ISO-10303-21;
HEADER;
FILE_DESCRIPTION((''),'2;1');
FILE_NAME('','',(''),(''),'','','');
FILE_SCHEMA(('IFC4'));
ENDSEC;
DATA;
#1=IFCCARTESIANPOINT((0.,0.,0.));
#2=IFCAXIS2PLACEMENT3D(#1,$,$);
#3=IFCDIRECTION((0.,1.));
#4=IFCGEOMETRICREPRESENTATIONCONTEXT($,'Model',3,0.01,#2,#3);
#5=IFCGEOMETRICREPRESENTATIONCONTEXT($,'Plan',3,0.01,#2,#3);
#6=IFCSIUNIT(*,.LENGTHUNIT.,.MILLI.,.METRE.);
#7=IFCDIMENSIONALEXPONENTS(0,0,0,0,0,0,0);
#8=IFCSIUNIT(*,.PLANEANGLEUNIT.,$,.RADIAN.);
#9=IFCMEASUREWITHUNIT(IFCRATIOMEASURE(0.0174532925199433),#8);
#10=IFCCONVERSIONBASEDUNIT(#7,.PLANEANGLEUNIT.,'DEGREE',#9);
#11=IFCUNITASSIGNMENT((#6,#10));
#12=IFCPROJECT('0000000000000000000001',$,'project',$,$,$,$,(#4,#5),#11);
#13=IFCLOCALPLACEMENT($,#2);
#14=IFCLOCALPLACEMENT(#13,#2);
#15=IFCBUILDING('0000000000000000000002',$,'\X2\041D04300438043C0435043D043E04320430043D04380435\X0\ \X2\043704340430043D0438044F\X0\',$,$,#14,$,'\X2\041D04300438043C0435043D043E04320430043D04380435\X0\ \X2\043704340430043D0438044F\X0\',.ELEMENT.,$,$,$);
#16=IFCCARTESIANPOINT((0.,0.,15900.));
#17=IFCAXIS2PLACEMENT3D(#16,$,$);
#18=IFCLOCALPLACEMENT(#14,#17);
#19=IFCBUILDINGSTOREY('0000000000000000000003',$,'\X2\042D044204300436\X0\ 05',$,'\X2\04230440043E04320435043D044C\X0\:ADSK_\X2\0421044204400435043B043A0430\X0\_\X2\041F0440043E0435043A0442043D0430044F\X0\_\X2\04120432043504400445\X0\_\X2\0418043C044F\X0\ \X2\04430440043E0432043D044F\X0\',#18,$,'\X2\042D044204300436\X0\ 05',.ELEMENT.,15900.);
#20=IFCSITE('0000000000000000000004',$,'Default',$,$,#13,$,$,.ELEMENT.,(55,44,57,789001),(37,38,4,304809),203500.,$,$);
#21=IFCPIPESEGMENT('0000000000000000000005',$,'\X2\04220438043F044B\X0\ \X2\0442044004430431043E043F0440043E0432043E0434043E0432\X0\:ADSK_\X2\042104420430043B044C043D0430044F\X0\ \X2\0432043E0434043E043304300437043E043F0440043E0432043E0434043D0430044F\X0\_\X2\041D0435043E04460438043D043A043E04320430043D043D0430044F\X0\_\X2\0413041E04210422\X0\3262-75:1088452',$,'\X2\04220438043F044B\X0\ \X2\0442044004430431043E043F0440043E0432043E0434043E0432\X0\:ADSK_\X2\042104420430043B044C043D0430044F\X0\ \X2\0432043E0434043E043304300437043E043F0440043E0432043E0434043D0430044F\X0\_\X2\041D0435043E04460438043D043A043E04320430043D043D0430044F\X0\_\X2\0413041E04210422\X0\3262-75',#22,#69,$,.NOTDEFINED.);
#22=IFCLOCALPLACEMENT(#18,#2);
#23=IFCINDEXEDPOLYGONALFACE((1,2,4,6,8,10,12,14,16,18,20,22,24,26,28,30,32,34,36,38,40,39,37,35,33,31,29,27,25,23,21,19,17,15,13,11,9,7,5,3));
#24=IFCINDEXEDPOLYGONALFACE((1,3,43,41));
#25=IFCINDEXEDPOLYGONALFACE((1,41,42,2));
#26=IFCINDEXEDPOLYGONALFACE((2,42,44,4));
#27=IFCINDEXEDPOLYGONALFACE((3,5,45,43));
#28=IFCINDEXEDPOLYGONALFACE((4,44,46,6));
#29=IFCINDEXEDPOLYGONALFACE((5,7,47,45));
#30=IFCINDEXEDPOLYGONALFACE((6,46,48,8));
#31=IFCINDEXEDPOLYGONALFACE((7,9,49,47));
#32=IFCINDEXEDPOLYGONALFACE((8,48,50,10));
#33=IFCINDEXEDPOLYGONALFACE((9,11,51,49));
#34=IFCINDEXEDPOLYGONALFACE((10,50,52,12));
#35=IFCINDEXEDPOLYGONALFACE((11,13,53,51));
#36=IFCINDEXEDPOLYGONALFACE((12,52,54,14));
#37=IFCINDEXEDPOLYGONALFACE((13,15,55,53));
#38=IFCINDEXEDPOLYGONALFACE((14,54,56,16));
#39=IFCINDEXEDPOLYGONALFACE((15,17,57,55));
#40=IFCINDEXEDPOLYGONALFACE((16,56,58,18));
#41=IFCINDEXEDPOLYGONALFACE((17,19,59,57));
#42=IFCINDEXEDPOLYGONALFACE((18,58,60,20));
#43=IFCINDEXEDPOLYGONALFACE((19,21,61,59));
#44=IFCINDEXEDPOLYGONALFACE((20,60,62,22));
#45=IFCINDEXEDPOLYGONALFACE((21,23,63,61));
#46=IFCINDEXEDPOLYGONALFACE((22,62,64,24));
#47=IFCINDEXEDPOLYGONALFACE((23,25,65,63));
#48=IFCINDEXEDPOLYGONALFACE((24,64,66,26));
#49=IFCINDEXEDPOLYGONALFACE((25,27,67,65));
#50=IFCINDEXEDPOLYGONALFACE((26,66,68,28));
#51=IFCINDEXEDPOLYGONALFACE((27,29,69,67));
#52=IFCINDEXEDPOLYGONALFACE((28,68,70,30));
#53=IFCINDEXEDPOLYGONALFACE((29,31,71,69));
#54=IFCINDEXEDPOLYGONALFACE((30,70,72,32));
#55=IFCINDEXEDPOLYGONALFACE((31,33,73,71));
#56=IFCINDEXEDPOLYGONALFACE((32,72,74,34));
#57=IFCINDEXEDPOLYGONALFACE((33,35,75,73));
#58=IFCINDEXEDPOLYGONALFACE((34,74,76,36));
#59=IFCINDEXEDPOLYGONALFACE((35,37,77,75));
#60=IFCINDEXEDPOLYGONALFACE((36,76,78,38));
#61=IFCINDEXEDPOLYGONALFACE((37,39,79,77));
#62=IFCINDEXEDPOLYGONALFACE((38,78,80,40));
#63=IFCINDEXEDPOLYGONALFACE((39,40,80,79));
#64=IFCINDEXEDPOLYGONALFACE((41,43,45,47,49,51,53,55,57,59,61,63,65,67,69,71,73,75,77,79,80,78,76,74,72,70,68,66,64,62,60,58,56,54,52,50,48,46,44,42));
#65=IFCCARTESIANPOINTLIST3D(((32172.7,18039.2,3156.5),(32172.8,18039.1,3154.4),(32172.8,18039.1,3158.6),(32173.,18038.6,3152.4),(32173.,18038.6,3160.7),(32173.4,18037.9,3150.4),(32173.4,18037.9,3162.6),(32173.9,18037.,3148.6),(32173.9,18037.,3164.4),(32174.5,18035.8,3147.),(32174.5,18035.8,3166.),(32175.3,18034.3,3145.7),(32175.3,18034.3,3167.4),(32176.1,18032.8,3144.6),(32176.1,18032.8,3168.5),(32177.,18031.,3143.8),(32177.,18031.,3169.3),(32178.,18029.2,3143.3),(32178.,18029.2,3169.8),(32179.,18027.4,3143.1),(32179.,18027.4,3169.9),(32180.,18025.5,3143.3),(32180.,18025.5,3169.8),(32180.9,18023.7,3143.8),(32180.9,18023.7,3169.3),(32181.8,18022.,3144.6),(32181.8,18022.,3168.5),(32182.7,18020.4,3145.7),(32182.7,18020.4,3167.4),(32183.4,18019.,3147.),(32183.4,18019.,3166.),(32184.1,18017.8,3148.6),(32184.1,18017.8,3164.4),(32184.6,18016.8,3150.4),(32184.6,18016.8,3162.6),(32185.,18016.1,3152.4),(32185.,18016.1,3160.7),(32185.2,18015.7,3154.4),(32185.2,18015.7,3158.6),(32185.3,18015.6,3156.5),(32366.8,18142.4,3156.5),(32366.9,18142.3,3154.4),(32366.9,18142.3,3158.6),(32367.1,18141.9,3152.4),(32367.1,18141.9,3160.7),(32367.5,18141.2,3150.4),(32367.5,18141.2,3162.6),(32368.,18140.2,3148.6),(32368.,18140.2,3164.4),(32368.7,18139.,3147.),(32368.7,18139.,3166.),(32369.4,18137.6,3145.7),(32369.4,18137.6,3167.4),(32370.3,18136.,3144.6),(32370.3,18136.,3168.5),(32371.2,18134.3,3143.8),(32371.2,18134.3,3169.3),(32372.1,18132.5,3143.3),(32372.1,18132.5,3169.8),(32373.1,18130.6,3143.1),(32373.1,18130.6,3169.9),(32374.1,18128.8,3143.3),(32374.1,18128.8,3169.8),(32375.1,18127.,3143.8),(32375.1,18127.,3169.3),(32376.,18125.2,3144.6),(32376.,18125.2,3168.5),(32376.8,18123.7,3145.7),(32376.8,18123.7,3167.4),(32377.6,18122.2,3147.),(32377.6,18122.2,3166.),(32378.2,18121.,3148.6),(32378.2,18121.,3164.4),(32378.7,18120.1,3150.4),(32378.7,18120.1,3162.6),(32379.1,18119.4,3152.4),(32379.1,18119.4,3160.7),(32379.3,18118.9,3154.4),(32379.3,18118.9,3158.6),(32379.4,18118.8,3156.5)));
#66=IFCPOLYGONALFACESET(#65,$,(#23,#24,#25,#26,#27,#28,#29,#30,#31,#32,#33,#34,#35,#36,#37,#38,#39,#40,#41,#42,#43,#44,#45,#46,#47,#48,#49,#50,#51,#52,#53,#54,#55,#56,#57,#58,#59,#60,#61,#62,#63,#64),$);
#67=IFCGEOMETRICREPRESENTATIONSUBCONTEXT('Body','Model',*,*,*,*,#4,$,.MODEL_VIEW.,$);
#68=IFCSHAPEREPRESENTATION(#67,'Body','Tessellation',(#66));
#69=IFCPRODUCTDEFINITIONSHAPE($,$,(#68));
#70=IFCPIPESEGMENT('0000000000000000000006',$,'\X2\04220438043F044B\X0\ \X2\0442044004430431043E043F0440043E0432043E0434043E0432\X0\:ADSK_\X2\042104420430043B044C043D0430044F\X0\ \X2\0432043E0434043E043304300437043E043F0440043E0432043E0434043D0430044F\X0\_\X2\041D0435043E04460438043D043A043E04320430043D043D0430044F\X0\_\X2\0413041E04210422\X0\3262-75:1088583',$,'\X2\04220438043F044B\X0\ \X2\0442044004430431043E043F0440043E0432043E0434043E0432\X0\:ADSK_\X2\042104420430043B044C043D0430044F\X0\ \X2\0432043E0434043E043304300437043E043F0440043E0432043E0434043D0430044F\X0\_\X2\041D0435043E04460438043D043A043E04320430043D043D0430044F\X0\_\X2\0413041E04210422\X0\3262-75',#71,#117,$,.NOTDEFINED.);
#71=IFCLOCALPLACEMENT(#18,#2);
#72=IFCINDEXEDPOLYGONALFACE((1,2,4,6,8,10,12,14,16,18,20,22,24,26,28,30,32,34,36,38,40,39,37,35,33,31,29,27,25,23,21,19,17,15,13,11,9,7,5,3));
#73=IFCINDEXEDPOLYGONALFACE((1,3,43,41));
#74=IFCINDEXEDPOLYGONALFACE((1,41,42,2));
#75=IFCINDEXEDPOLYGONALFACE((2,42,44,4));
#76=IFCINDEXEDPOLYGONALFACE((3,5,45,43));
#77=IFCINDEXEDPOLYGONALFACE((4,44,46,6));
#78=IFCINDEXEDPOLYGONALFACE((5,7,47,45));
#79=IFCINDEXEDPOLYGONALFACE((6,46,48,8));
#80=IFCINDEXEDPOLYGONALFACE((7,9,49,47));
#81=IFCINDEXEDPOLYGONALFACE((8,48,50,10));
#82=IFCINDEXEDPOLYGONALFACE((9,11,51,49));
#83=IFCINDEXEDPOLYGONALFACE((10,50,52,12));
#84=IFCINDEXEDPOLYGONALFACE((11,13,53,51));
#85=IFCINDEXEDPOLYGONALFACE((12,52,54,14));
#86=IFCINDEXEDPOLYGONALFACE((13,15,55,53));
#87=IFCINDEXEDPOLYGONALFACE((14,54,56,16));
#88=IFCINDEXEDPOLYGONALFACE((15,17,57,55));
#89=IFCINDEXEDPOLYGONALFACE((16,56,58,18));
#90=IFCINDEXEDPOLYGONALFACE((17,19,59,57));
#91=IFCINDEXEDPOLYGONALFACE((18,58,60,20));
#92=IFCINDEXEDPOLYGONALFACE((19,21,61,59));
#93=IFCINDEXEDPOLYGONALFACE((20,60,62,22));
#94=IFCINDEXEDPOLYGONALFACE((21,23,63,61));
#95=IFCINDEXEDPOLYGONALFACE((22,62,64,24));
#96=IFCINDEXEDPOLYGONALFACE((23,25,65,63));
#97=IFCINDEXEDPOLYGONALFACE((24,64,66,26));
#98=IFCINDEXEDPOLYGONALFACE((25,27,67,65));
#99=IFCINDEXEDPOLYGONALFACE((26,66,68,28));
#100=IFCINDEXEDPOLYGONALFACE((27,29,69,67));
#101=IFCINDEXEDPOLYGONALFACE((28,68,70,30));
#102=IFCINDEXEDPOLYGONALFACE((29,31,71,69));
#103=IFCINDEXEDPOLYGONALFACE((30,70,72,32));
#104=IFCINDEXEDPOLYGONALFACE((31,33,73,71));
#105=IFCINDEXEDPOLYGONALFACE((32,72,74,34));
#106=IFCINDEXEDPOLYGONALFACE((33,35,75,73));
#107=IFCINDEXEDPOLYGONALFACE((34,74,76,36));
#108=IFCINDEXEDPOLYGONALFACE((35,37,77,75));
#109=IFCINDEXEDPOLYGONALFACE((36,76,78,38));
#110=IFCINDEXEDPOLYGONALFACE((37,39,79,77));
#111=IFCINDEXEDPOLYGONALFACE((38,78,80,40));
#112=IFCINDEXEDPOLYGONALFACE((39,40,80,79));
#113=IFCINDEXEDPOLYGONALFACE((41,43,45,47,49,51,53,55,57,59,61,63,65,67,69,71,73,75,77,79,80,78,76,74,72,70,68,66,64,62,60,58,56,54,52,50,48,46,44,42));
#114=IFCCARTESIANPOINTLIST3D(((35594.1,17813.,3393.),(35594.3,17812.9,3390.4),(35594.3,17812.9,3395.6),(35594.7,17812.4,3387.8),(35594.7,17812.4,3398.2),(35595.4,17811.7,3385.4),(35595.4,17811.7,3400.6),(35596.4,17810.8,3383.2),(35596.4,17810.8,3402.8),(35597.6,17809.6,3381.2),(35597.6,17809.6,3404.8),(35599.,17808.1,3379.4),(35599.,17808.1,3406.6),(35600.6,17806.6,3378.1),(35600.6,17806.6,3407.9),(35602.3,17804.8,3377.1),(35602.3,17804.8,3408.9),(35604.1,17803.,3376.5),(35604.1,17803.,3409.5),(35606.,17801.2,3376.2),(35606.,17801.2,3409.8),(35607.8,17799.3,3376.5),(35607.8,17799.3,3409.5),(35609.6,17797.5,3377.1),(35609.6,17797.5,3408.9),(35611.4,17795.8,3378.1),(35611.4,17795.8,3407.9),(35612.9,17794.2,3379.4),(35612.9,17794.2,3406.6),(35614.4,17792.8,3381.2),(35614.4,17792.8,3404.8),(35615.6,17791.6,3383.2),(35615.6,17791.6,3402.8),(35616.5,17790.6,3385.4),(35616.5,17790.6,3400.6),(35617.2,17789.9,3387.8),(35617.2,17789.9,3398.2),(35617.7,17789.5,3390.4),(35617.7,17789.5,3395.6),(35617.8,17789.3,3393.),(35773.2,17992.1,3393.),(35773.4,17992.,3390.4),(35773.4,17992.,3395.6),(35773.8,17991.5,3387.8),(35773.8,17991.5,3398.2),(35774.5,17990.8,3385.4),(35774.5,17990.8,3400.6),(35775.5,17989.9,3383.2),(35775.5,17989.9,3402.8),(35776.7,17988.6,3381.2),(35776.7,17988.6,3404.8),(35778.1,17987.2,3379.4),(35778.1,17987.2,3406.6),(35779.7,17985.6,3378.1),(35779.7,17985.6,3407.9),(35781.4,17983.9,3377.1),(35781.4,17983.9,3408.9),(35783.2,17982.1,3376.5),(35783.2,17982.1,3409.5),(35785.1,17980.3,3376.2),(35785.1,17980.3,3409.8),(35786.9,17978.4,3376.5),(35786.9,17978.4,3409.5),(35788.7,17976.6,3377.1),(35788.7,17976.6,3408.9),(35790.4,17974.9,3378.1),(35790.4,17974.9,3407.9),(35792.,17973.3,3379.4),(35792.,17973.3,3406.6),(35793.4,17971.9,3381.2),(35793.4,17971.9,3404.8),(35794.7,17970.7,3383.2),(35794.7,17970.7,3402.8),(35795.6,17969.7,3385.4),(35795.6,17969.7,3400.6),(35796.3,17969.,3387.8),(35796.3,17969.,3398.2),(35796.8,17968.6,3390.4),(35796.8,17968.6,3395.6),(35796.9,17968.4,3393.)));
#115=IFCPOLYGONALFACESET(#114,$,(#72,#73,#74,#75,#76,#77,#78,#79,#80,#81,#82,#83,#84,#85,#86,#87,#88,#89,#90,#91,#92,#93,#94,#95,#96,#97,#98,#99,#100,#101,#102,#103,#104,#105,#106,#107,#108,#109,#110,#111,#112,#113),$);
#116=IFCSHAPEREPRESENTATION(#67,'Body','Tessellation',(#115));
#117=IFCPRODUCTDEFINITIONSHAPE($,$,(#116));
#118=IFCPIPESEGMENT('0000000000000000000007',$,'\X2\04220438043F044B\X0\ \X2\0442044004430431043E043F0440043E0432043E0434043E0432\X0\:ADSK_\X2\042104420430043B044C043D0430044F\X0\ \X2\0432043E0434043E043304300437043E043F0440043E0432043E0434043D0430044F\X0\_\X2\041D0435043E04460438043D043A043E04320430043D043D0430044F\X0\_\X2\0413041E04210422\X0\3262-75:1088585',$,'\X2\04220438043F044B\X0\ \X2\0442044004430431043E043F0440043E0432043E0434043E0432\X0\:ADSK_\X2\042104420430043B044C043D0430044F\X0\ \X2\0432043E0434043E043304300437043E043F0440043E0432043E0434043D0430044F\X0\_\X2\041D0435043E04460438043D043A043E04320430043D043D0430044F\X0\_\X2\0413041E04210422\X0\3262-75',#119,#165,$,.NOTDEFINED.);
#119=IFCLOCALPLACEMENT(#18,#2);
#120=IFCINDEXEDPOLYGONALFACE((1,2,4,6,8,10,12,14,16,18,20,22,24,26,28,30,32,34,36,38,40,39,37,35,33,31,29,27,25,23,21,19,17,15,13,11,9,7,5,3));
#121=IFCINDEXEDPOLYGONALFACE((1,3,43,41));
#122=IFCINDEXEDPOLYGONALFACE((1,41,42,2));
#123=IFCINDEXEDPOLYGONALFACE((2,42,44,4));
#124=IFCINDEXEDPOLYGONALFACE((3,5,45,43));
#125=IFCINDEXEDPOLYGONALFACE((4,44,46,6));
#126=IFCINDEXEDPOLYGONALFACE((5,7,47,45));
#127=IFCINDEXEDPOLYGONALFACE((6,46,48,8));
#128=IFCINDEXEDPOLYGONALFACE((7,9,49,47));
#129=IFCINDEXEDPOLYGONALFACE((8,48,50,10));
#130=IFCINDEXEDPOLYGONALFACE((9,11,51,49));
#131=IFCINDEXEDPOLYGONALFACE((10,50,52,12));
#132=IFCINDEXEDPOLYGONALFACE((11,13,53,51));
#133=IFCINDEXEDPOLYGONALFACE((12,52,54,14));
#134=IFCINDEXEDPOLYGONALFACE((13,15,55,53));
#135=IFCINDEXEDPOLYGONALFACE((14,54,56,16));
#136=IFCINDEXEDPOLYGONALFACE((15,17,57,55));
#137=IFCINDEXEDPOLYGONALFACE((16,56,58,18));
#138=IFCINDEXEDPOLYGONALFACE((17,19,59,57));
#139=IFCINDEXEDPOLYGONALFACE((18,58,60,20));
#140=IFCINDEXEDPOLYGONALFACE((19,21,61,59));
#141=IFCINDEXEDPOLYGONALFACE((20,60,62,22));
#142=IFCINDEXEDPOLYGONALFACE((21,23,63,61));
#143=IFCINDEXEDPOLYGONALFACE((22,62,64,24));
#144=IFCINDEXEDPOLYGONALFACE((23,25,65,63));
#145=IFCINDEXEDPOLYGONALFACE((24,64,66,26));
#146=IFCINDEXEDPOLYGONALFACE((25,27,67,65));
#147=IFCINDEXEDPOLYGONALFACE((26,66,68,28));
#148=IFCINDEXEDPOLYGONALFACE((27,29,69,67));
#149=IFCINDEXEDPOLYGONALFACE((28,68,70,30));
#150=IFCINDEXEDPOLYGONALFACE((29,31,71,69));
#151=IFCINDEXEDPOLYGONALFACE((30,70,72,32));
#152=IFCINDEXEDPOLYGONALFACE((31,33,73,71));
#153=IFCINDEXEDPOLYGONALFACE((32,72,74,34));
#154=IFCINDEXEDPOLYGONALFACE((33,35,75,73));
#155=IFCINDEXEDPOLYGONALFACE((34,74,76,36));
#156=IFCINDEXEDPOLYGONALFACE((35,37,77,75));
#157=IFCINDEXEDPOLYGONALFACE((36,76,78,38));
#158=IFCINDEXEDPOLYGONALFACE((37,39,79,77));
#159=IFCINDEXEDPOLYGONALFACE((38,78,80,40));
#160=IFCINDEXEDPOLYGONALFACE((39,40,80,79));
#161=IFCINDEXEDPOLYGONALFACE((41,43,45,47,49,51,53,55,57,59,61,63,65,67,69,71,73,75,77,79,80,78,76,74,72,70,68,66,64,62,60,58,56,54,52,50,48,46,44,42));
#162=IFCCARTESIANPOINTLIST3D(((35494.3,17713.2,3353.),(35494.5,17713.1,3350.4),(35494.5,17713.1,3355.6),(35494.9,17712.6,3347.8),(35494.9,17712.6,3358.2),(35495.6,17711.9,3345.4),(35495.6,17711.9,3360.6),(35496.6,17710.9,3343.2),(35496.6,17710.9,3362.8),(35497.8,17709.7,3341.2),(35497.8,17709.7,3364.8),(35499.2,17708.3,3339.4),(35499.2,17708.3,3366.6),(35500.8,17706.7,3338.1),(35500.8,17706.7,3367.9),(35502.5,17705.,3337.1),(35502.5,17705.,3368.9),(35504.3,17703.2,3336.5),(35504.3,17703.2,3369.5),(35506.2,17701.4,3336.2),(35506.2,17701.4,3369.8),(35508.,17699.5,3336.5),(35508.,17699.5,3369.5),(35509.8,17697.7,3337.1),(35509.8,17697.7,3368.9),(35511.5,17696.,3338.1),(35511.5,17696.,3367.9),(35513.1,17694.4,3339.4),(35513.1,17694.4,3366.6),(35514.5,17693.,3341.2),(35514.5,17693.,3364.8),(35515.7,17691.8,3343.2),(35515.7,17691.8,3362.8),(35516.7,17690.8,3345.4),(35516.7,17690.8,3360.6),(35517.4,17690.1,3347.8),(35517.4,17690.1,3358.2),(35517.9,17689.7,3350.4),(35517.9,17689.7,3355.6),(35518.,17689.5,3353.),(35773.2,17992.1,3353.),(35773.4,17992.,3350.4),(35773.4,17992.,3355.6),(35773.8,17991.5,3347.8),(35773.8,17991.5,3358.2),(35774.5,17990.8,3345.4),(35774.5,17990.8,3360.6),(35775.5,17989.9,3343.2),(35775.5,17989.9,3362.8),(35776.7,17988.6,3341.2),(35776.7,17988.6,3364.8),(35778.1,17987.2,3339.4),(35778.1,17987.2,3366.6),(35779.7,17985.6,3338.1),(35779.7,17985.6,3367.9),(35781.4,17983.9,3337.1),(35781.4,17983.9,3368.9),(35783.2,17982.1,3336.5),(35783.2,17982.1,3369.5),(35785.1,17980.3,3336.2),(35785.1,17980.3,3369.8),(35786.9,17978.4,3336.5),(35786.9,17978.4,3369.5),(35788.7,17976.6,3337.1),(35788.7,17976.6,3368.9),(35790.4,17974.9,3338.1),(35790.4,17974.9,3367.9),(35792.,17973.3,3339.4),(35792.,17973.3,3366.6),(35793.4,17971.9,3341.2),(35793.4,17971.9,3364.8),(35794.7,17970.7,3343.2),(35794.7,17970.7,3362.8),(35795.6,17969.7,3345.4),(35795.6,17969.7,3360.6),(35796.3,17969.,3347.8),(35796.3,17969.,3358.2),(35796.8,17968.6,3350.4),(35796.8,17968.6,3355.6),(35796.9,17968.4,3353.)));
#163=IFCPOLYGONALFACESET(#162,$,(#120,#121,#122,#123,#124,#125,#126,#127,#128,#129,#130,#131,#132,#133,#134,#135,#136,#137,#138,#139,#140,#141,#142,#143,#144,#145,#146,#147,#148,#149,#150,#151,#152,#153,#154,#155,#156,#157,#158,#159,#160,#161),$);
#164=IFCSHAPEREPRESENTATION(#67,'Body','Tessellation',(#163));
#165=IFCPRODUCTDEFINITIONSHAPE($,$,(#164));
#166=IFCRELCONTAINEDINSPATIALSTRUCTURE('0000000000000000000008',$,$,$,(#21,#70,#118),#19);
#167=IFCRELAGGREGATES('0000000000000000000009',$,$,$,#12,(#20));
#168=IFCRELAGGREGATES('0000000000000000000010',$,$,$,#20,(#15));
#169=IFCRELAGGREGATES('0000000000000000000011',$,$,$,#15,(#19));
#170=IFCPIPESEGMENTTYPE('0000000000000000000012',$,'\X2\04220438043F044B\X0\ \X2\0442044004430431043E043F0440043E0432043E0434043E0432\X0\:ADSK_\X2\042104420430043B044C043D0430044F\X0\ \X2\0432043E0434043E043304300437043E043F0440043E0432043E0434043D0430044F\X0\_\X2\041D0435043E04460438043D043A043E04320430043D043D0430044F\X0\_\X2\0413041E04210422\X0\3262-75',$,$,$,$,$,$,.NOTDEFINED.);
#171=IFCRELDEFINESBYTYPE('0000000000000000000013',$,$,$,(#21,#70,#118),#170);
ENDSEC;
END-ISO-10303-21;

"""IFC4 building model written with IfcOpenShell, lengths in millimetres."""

from ifc_helpers import new_model, entity, si_unit, converted_unit, direction, frame, origin, place, context, subcontext, project, spatial, indexed_curve, outline, extrude, type_object, element, save


model = new_model("IFC4")

# Units and contexts
model_context = context("Model", 3, precision=0.01, world=origin(), true_north=direction((0.0, 1.0)))
plan_context = context("Plan", 3, precision=0.01, world=origin(), true_north=direction((0.0, 1.0)))
body_context = subcontext(model_context, "Body", "Model", "MODEL_VIEW")
ifc_project = project(units=[si_unit("LENGTHUNIT", "METRE", prefix="MILLI"), converted_unit("PLANEANGLEUNIT", "DEGREE", entity("IfcRatioMeasure", 0.0174532925199433), si_unit("PLANEANGLEUNIT", "RADIAN"), dimensions=[0, 0, 0, 0, 0, 0, 0])], contexts=[model_context, plan_context])

# Site, building, storey
site_placement = place(None, origin())
site = spatial("IfcSite", under=ifc_project, at=site_placement, Name="Default", CompositionType="ELEMENT", RefLatitude=(55, 44, 57, 789001), RefLongitude=(37, 38, 4, 304809), RefElevation=203500.0)
building_placement = place(site_placement, origin())
building = spatial("IfcBuilding", under=site, at=building_placement, Name="Наименование здания", LongName="Наименование здания", CompositionType="ELEMENT")
storey_placement = place(building_placement, frame((0.0, 0.0, 15900.0)))
storey = spatial("IfcBuildingStorey", under=building, at=storey_placement, Name="Этаж 05", ObjectType="Уровень:ADSK_Стрелка_Проектная_Вверх_Имя уровня", LongName="Этаж 05", CompositionType="ELEMENT", Elevation=15900.0)

# Pipe segments
placement = place(storey_placement, origin())
pipe_segment_type_1 = type_object("IfcPipeSegmentType", Name="Типы трубопроводов:ADSK_Стальная водогазопроводная_Неоцинкованная_ГОСТ3262-75", PredefinedType="NOTDEFINED")
element("IfcPipeSegment", 1, at=placement, inside=storey, type_object=pipe_segment_type_1, Name="Типы трубопроводов:ADSK_Стальная водогазопроводная_Неоцинкованная_ГОСТ3262-75:1088452", ObjectType="Типы трубопроводов:ADSK_Стальная водогазопроводная_Неоцинкованная_ГОСТ3262-75", PredefinedType="NOTDEFINED", context=body_context, shape_type="SweptSolid", body=[
    extrude(outline(indexed_curve([(13.4, 0.0), (13.2, 2.1), (12.7, 4.1), (11.9, 6.1), (10.8, 7.9), (9.5, 9.5), (7.9, 10.8), (6.1, 11.9), (4.1, 12.7), (2.1, 13.2), (0.0, 13.4), (-2.1, 13.2), (-4.1, 12.7), (-6.1, 11.9), (-7.9, 10.8), (-9.5, 9.5), (-10.8, 7.9), (-11.9, 6.1), (-12.7, 4.1), (-13.2, 2.1), (-13.4, 0.0), (-13.2, -2.1), (-12.7, -4.1), (-11.9, -6.1), (-10.8, -7.9), (-9.5, -9.5), (-7.9, -10.8), (-6.1, -11.9), (-4.1, -12.7), (-2.1, -13.2), (0.0, -13.4), (2.1, -13.2), (4.1, -12.7), (6.1, -11.9), (7.9, -10.8), (9.5, -9.5), (10.8, -7.9), (11.9, -6.1), (12.7, -4.1), (13.2, -2.1), (13.4, 0.0)], self_intersect=False)), frame((32179.0, 18027.4, 3156.5), z_axis=(0.882948, 0.469472, 0.0), x_axis=(0.469472, -0.882948, 0.0)), (0.0, 0.0, 1.0), 219.9),
])
element("IfcPipeSegment", 2, at=placement, inside=storey, type_object=pipe_segment_type_1, Name="Типы трубопроводов:ADSK_Стальная водогазопроводная_Неоцинкованная_ГОСТ3262-75:1088583", ObjectType="Типы трубопроводов:ADSK_Стальная водогазопроводная_Неоцинкованная_ГОСТ3262-75", PredefinedType="NOTDEFINED", context=body_context, shape_type="SweptSolid", body=[
    extrude(outline(indexed_curve([(16.7, 0.0), (16.5, 2.6), (15.9, 5.2), (14.9, 7.6), (13.6, 9.8), (11.8, 11.8), (9.8, 13.6), (7.6, 14.9), (5.2, 15.9), (2.6, 16.5), (0.0, 16.8), (-2.6, 16.5), (-5.2, 15.9), (-7.6, 14.9), (-9.8, 13.6), (-11.8, 11.8), (-13.6, 9.8), (-14.9, 7.6), (-15.9, 5.2), (-16.5, 2.6), (-16.7, 0.0), (-16.5, -2.6), (-15.9, -5.2), (-14.9, -7.6), (-13.6, -9.8), (-11.8, -11.8), (-9.8, -13.6), (-7.6, -14.9), (-5.2, -15.9), (-2.6, -16.5), (0.0, -16.8), (2.6, -16.5), (5.2, -15.9), (7.6, -14.9), (9.8, -13.6), (11.8, -11.8), (13.6, -9.8), (14.9, -7.6), (15.9, -5.2), (16.5, -2.6), (16.7, 0.0)], self_intersect=False)), frame((35606.0, 17801.2, 3393.0), z_axis=(0.707107, 0.707107, 0.0), x_axis=(0.707107, -0.707107, 0.0)), (0.0, 0.0, 1.0), 253.3),
])
element("IfcPipeSegment", 3, at=placement, inside=storey, type_object=pipe_segment_type_1, Name="Типы трубопроводов:ADSK_Стальная водогазопроводная_Неоцинкованная_ГОСТ3262-75:1088585", ObjectType="Типы трубопроводов:ADSK_Стальная водогазопроводная_Неоцинкованная_ГОСТ3262-75", PredefinedType="NOTDEFINED", context=body_context, shape_type="SweptSolid", body=[
    extrude(outline(indexed_curve([(16.7, 0.0), (16.5, 2.6), (15.9, 5.2), (14.9, 7.6), (13.6, 9.8), (11.8, 11.8), (9.8, 13.6), (7.6, 14.9), (5.2, 15.9), (2.6, 16.5), (0.0, 16.8), (-2.6, 16.5), (-5.2, 15.9), (-7.6, 14.9), (-9.8, 13.6), (-11.8, 11.8), (-13.6, 9.8), (-14.9, 7.6), (-15.9, 5.2), (-16.5, 2.6), (-16.7, 0.0), (-16.5, -2.6), (-15.9, -5.2), (-14.9, -7.6), (-13.6, -9.8), (-11.8, -11.8), (-9.8, -13.6), (-7.6, -14.9), (-5.2, -15.9), (-2.6, -16.5), (0.0, -16.8), (2.6, -16.5), (5.2, -15.9), (7.6, -14.9), (9.8, -13.6), (11.8, -11.8), (13.6, -9.8), (14.9, -7.6), (15.9, -5.2), (16.5, -2.6), (16.7, 0.0)], self_intersect=False)), frame((35506.2, 17701.4, 3353.0), z_axis=(0.707107, 0.707107, 0.0), x_axis=(0.707107, -0.707107, 0.0)), (0.0, 0.0, 1.0), 394.4),
])

save(model, "model.ifc")
